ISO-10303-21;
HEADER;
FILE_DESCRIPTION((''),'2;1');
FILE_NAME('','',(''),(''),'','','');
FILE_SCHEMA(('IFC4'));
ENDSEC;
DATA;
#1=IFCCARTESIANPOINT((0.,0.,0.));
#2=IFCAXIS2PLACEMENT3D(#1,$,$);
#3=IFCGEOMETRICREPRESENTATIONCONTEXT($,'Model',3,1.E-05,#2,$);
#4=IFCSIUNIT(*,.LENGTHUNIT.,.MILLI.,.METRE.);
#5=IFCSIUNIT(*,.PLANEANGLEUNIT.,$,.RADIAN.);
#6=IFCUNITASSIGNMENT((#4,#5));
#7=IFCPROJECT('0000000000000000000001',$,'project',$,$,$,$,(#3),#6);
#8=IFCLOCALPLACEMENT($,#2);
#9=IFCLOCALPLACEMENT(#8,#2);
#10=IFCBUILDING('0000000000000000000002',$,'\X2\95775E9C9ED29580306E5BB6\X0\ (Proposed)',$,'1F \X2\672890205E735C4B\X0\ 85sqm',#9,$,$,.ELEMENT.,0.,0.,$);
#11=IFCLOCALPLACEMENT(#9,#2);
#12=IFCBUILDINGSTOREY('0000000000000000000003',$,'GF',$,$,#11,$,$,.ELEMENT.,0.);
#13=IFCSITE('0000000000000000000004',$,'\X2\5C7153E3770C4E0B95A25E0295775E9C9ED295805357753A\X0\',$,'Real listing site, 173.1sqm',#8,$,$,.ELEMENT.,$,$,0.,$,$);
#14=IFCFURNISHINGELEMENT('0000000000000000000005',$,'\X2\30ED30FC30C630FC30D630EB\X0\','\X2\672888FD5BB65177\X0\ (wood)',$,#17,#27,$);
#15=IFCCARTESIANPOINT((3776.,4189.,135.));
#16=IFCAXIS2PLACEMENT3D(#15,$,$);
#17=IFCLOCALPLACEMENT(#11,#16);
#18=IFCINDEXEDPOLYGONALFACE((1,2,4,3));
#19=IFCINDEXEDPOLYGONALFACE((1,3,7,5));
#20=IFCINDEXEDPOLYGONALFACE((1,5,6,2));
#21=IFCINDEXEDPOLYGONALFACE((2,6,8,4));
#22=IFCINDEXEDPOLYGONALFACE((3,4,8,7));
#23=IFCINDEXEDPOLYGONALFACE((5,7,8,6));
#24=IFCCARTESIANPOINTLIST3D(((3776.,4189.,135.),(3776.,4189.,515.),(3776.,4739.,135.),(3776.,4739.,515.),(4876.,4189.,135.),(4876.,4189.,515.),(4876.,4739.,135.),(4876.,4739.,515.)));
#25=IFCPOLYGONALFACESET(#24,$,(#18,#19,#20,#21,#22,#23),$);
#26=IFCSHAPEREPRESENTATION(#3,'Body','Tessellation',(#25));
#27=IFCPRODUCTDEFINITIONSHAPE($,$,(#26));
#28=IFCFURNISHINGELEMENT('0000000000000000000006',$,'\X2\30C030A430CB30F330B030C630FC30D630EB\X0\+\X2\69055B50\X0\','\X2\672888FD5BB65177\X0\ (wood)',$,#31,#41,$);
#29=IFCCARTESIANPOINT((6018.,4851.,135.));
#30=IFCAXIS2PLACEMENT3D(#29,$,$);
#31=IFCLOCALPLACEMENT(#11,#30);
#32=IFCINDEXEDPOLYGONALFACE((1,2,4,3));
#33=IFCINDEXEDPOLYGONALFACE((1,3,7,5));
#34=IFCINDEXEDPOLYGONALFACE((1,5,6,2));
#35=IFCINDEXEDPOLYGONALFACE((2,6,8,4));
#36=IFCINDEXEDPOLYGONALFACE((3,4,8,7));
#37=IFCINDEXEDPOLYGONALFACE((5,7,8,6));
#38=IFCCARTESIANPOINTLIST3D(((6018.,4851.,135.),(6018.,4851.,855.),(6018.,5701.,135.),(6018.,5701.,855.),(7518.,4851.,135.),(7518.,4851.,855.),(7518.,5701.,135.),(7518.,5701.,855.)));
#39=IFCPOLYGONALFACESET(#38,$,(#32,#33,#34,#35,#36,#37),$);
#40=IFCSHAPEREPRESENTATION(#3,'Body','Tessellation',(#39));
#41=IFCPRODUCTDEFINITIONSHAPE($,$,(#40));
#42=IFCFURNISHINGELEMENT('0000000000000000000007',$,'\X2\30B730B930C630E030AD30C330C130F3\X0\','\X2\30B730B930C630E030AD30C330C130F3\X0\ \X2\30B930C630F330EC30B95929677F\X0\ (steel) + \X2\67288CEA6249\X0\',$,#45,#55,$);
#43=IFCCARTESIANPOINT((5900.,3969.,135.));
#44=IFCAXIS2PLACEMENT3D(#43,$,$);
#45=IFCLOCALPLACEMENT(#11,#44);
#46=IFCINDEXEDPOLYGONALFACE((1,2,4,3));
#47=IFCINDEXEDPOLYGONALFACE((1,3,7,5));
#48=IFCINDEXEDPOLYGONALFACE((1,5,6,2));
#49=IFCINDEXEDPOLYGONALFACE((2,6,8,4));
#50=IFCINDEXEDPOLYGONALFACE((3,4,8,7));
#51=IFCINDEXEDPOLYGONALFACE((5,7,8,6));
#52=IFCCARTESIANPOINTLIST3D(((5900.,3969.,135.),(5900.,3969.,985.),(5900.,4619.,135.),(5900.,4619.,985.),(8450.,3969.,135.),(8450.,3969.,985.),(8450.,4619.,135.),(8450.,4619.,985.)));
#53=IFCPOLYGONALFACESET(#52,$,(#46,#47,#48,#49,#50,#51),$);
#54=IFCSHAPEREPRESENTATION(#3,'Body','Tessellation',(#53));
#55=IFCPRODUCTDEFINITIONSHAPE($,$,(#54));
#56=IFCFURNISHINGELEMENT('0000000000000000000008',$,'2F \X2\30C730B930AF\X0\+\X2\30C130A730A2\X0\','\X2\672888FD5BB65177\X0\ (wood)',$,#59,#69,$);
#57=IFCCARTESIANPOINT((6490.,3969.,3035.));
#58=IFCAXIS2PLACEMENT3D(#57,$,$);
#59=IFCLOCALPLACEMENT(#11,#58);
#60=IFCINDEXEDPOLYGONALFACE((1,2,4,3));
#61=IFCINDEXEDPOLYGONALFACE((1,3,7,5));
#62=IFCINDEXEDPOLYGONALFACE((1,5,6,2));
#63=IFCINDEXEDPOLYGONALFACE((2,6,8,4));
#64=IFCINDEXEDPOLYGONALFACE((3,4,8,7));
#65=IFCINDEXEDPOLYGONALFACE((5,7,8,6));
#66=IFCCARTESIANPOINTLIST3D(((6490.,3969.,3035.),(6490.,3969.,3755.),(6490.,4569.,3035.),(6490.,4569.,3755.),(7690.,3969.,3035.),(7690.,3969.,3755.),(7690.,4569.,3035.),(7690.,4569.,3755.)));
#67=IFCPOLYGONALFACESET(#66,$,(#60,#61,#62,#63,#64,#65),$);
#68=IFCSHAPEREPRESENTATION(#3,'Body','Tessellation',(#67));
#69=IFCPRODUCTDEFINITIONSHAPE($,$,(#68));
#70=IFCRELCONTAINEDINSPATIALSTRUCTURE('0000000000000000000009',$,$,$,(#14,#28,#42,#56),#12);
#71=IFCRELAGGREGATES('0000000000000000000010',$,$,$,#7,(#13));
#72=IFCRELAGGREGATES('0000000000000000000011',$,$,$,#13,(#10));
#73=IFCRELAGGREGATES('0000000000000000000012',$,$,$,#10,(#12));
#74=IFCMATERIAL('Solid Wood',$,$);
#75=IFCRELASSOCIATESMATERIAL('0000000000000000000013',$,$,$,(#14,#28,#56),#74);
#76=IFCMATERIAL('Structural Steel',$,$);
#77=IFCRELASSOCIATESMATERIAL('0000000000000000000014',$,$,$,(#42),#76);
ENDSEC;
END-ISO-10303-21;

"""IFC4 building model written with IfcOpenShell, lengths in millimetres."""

from ifc_helpers import new_model, si_unit, frame, frame_2d, origin, place, context, project, spatial, rectangle, extrude, material, element, save


model = new_model("IFC4")

# Units and contexts
model_context = context("Model", 3, precision=1e-05, world=origin())
ifc_project = project(units=[si_unit("LENGTHUNIT", "METRE", prefix="MILLI"), si_unit("PLANEANGLEUNIT", "RADIAN")], contexts=[model_context])

# Site, building, storey
site_placement = place(None, origin())
site = spatial("IfcSite", under=ifc_project, at=site_placement, Name="山口県下関市長府黒門南町", ObjectType="Real listing site, 173.1sqm", CompositionType="ELEMENT", RefElevation=0.0)
building_placement = place(site_placement, origin())
building = spatial("IfcBuilding", under=site, at=building_placement, Name="長府黒門の家 (Proposed)", ObjectType="1F 木造平屋 85sqm", CompositionType="ELEMENT", ElevationOfRefHeight=0.0, ElevationOfTerrain=0.0)
storey_placement = place(building_placement, origin())
storey = spatial("IfcBuildingStorey", under=building, at=storey_placement, Name="GF", CompositionType="ELEMENT", Elevation=0.0)

# Shared definitions
ifc_material_1 = material(Name="Solid Wood")

# Shared definitions
ifc_material_2 = material(Name="Structural Steel")

# Furnishing elements
furnishing_1_placement = place(storey_placement, frame((3776.0, 4189.0, 135.0)))
element("IfcFurnishingElement", 1, at=furnishing_1_placement, inside=storey, material=ifc_material_1, Name="ローテーブル", Description="木製家具 (wood)", context=model_context, shape_type="SweptSolid", body=[
    extrude(rectangle(XDim=1100.0, YDim=550.0, at=frame_2d((550.0, 275.0))), frame((3776.0, 4189.0, 135.0)), (0.0, 0.0, 1.0), 380.0),
])
furnishing_2_placement = place(storey_placement, frame((6018.0, 4851.0, 135.0)))
element("IfcFurnishingElement", 2, at=furnishing_2_placement, inside=storey, material=ifc_material_1, Name="ダイニングテーブル+椅子", Description="木製家具 (wood)", context=model_context, shape_type="SweptSolid", body=[
    extrude(rectangle(XDim=1500.0, YDim=850.0, at=frame_2d((750.0, 425.0))), frame((6018.0, 4851.0, 135.0)), (0.0, 0.0, 1.0), 720.0),
])
furnishing_3_placement = place(storey_placement, frame((5900.0, 3969.0, 135.0)))
element("IfcFurnishingElement", 3, at=furnishing_3_placement, inside=storey, material=ifc_material_2, Name="システムキッチン", Description="システムキッチン ステンレス天板 (steel) + 木質扉", context=model_context, shape_type="SweptSolid", body=[
    extrude(rectangle(XDim=2550.0, YDim=650.0, at=frame_2d((1275.0, 325.0))), frame((5900.0, 3969.0, 135.0)), (0.0, 0.0, 1.0), 850.0),
])
furnishing_4_placement = place(storey_placement, frame((6490.0, 3969.0, 3035.0)))
element("IfcFurnishingElement", 4, at=furnishing_4_placement, inside=storey, material=ifc_material_1, Name="2F デスク+チェア", Description="木製家具 (wood)", context=model_context, shape_type="SweptSolid", body=[
    extrude(rectangle(XDim=1200.0, YDim=600.0, at=frame_2d((600.0, 300.0))), frame((6490.0, 3969.0, 3035.0)), (0.0, 0.0, 1.0), 720.0),
])

save(model, "model.ifc")
